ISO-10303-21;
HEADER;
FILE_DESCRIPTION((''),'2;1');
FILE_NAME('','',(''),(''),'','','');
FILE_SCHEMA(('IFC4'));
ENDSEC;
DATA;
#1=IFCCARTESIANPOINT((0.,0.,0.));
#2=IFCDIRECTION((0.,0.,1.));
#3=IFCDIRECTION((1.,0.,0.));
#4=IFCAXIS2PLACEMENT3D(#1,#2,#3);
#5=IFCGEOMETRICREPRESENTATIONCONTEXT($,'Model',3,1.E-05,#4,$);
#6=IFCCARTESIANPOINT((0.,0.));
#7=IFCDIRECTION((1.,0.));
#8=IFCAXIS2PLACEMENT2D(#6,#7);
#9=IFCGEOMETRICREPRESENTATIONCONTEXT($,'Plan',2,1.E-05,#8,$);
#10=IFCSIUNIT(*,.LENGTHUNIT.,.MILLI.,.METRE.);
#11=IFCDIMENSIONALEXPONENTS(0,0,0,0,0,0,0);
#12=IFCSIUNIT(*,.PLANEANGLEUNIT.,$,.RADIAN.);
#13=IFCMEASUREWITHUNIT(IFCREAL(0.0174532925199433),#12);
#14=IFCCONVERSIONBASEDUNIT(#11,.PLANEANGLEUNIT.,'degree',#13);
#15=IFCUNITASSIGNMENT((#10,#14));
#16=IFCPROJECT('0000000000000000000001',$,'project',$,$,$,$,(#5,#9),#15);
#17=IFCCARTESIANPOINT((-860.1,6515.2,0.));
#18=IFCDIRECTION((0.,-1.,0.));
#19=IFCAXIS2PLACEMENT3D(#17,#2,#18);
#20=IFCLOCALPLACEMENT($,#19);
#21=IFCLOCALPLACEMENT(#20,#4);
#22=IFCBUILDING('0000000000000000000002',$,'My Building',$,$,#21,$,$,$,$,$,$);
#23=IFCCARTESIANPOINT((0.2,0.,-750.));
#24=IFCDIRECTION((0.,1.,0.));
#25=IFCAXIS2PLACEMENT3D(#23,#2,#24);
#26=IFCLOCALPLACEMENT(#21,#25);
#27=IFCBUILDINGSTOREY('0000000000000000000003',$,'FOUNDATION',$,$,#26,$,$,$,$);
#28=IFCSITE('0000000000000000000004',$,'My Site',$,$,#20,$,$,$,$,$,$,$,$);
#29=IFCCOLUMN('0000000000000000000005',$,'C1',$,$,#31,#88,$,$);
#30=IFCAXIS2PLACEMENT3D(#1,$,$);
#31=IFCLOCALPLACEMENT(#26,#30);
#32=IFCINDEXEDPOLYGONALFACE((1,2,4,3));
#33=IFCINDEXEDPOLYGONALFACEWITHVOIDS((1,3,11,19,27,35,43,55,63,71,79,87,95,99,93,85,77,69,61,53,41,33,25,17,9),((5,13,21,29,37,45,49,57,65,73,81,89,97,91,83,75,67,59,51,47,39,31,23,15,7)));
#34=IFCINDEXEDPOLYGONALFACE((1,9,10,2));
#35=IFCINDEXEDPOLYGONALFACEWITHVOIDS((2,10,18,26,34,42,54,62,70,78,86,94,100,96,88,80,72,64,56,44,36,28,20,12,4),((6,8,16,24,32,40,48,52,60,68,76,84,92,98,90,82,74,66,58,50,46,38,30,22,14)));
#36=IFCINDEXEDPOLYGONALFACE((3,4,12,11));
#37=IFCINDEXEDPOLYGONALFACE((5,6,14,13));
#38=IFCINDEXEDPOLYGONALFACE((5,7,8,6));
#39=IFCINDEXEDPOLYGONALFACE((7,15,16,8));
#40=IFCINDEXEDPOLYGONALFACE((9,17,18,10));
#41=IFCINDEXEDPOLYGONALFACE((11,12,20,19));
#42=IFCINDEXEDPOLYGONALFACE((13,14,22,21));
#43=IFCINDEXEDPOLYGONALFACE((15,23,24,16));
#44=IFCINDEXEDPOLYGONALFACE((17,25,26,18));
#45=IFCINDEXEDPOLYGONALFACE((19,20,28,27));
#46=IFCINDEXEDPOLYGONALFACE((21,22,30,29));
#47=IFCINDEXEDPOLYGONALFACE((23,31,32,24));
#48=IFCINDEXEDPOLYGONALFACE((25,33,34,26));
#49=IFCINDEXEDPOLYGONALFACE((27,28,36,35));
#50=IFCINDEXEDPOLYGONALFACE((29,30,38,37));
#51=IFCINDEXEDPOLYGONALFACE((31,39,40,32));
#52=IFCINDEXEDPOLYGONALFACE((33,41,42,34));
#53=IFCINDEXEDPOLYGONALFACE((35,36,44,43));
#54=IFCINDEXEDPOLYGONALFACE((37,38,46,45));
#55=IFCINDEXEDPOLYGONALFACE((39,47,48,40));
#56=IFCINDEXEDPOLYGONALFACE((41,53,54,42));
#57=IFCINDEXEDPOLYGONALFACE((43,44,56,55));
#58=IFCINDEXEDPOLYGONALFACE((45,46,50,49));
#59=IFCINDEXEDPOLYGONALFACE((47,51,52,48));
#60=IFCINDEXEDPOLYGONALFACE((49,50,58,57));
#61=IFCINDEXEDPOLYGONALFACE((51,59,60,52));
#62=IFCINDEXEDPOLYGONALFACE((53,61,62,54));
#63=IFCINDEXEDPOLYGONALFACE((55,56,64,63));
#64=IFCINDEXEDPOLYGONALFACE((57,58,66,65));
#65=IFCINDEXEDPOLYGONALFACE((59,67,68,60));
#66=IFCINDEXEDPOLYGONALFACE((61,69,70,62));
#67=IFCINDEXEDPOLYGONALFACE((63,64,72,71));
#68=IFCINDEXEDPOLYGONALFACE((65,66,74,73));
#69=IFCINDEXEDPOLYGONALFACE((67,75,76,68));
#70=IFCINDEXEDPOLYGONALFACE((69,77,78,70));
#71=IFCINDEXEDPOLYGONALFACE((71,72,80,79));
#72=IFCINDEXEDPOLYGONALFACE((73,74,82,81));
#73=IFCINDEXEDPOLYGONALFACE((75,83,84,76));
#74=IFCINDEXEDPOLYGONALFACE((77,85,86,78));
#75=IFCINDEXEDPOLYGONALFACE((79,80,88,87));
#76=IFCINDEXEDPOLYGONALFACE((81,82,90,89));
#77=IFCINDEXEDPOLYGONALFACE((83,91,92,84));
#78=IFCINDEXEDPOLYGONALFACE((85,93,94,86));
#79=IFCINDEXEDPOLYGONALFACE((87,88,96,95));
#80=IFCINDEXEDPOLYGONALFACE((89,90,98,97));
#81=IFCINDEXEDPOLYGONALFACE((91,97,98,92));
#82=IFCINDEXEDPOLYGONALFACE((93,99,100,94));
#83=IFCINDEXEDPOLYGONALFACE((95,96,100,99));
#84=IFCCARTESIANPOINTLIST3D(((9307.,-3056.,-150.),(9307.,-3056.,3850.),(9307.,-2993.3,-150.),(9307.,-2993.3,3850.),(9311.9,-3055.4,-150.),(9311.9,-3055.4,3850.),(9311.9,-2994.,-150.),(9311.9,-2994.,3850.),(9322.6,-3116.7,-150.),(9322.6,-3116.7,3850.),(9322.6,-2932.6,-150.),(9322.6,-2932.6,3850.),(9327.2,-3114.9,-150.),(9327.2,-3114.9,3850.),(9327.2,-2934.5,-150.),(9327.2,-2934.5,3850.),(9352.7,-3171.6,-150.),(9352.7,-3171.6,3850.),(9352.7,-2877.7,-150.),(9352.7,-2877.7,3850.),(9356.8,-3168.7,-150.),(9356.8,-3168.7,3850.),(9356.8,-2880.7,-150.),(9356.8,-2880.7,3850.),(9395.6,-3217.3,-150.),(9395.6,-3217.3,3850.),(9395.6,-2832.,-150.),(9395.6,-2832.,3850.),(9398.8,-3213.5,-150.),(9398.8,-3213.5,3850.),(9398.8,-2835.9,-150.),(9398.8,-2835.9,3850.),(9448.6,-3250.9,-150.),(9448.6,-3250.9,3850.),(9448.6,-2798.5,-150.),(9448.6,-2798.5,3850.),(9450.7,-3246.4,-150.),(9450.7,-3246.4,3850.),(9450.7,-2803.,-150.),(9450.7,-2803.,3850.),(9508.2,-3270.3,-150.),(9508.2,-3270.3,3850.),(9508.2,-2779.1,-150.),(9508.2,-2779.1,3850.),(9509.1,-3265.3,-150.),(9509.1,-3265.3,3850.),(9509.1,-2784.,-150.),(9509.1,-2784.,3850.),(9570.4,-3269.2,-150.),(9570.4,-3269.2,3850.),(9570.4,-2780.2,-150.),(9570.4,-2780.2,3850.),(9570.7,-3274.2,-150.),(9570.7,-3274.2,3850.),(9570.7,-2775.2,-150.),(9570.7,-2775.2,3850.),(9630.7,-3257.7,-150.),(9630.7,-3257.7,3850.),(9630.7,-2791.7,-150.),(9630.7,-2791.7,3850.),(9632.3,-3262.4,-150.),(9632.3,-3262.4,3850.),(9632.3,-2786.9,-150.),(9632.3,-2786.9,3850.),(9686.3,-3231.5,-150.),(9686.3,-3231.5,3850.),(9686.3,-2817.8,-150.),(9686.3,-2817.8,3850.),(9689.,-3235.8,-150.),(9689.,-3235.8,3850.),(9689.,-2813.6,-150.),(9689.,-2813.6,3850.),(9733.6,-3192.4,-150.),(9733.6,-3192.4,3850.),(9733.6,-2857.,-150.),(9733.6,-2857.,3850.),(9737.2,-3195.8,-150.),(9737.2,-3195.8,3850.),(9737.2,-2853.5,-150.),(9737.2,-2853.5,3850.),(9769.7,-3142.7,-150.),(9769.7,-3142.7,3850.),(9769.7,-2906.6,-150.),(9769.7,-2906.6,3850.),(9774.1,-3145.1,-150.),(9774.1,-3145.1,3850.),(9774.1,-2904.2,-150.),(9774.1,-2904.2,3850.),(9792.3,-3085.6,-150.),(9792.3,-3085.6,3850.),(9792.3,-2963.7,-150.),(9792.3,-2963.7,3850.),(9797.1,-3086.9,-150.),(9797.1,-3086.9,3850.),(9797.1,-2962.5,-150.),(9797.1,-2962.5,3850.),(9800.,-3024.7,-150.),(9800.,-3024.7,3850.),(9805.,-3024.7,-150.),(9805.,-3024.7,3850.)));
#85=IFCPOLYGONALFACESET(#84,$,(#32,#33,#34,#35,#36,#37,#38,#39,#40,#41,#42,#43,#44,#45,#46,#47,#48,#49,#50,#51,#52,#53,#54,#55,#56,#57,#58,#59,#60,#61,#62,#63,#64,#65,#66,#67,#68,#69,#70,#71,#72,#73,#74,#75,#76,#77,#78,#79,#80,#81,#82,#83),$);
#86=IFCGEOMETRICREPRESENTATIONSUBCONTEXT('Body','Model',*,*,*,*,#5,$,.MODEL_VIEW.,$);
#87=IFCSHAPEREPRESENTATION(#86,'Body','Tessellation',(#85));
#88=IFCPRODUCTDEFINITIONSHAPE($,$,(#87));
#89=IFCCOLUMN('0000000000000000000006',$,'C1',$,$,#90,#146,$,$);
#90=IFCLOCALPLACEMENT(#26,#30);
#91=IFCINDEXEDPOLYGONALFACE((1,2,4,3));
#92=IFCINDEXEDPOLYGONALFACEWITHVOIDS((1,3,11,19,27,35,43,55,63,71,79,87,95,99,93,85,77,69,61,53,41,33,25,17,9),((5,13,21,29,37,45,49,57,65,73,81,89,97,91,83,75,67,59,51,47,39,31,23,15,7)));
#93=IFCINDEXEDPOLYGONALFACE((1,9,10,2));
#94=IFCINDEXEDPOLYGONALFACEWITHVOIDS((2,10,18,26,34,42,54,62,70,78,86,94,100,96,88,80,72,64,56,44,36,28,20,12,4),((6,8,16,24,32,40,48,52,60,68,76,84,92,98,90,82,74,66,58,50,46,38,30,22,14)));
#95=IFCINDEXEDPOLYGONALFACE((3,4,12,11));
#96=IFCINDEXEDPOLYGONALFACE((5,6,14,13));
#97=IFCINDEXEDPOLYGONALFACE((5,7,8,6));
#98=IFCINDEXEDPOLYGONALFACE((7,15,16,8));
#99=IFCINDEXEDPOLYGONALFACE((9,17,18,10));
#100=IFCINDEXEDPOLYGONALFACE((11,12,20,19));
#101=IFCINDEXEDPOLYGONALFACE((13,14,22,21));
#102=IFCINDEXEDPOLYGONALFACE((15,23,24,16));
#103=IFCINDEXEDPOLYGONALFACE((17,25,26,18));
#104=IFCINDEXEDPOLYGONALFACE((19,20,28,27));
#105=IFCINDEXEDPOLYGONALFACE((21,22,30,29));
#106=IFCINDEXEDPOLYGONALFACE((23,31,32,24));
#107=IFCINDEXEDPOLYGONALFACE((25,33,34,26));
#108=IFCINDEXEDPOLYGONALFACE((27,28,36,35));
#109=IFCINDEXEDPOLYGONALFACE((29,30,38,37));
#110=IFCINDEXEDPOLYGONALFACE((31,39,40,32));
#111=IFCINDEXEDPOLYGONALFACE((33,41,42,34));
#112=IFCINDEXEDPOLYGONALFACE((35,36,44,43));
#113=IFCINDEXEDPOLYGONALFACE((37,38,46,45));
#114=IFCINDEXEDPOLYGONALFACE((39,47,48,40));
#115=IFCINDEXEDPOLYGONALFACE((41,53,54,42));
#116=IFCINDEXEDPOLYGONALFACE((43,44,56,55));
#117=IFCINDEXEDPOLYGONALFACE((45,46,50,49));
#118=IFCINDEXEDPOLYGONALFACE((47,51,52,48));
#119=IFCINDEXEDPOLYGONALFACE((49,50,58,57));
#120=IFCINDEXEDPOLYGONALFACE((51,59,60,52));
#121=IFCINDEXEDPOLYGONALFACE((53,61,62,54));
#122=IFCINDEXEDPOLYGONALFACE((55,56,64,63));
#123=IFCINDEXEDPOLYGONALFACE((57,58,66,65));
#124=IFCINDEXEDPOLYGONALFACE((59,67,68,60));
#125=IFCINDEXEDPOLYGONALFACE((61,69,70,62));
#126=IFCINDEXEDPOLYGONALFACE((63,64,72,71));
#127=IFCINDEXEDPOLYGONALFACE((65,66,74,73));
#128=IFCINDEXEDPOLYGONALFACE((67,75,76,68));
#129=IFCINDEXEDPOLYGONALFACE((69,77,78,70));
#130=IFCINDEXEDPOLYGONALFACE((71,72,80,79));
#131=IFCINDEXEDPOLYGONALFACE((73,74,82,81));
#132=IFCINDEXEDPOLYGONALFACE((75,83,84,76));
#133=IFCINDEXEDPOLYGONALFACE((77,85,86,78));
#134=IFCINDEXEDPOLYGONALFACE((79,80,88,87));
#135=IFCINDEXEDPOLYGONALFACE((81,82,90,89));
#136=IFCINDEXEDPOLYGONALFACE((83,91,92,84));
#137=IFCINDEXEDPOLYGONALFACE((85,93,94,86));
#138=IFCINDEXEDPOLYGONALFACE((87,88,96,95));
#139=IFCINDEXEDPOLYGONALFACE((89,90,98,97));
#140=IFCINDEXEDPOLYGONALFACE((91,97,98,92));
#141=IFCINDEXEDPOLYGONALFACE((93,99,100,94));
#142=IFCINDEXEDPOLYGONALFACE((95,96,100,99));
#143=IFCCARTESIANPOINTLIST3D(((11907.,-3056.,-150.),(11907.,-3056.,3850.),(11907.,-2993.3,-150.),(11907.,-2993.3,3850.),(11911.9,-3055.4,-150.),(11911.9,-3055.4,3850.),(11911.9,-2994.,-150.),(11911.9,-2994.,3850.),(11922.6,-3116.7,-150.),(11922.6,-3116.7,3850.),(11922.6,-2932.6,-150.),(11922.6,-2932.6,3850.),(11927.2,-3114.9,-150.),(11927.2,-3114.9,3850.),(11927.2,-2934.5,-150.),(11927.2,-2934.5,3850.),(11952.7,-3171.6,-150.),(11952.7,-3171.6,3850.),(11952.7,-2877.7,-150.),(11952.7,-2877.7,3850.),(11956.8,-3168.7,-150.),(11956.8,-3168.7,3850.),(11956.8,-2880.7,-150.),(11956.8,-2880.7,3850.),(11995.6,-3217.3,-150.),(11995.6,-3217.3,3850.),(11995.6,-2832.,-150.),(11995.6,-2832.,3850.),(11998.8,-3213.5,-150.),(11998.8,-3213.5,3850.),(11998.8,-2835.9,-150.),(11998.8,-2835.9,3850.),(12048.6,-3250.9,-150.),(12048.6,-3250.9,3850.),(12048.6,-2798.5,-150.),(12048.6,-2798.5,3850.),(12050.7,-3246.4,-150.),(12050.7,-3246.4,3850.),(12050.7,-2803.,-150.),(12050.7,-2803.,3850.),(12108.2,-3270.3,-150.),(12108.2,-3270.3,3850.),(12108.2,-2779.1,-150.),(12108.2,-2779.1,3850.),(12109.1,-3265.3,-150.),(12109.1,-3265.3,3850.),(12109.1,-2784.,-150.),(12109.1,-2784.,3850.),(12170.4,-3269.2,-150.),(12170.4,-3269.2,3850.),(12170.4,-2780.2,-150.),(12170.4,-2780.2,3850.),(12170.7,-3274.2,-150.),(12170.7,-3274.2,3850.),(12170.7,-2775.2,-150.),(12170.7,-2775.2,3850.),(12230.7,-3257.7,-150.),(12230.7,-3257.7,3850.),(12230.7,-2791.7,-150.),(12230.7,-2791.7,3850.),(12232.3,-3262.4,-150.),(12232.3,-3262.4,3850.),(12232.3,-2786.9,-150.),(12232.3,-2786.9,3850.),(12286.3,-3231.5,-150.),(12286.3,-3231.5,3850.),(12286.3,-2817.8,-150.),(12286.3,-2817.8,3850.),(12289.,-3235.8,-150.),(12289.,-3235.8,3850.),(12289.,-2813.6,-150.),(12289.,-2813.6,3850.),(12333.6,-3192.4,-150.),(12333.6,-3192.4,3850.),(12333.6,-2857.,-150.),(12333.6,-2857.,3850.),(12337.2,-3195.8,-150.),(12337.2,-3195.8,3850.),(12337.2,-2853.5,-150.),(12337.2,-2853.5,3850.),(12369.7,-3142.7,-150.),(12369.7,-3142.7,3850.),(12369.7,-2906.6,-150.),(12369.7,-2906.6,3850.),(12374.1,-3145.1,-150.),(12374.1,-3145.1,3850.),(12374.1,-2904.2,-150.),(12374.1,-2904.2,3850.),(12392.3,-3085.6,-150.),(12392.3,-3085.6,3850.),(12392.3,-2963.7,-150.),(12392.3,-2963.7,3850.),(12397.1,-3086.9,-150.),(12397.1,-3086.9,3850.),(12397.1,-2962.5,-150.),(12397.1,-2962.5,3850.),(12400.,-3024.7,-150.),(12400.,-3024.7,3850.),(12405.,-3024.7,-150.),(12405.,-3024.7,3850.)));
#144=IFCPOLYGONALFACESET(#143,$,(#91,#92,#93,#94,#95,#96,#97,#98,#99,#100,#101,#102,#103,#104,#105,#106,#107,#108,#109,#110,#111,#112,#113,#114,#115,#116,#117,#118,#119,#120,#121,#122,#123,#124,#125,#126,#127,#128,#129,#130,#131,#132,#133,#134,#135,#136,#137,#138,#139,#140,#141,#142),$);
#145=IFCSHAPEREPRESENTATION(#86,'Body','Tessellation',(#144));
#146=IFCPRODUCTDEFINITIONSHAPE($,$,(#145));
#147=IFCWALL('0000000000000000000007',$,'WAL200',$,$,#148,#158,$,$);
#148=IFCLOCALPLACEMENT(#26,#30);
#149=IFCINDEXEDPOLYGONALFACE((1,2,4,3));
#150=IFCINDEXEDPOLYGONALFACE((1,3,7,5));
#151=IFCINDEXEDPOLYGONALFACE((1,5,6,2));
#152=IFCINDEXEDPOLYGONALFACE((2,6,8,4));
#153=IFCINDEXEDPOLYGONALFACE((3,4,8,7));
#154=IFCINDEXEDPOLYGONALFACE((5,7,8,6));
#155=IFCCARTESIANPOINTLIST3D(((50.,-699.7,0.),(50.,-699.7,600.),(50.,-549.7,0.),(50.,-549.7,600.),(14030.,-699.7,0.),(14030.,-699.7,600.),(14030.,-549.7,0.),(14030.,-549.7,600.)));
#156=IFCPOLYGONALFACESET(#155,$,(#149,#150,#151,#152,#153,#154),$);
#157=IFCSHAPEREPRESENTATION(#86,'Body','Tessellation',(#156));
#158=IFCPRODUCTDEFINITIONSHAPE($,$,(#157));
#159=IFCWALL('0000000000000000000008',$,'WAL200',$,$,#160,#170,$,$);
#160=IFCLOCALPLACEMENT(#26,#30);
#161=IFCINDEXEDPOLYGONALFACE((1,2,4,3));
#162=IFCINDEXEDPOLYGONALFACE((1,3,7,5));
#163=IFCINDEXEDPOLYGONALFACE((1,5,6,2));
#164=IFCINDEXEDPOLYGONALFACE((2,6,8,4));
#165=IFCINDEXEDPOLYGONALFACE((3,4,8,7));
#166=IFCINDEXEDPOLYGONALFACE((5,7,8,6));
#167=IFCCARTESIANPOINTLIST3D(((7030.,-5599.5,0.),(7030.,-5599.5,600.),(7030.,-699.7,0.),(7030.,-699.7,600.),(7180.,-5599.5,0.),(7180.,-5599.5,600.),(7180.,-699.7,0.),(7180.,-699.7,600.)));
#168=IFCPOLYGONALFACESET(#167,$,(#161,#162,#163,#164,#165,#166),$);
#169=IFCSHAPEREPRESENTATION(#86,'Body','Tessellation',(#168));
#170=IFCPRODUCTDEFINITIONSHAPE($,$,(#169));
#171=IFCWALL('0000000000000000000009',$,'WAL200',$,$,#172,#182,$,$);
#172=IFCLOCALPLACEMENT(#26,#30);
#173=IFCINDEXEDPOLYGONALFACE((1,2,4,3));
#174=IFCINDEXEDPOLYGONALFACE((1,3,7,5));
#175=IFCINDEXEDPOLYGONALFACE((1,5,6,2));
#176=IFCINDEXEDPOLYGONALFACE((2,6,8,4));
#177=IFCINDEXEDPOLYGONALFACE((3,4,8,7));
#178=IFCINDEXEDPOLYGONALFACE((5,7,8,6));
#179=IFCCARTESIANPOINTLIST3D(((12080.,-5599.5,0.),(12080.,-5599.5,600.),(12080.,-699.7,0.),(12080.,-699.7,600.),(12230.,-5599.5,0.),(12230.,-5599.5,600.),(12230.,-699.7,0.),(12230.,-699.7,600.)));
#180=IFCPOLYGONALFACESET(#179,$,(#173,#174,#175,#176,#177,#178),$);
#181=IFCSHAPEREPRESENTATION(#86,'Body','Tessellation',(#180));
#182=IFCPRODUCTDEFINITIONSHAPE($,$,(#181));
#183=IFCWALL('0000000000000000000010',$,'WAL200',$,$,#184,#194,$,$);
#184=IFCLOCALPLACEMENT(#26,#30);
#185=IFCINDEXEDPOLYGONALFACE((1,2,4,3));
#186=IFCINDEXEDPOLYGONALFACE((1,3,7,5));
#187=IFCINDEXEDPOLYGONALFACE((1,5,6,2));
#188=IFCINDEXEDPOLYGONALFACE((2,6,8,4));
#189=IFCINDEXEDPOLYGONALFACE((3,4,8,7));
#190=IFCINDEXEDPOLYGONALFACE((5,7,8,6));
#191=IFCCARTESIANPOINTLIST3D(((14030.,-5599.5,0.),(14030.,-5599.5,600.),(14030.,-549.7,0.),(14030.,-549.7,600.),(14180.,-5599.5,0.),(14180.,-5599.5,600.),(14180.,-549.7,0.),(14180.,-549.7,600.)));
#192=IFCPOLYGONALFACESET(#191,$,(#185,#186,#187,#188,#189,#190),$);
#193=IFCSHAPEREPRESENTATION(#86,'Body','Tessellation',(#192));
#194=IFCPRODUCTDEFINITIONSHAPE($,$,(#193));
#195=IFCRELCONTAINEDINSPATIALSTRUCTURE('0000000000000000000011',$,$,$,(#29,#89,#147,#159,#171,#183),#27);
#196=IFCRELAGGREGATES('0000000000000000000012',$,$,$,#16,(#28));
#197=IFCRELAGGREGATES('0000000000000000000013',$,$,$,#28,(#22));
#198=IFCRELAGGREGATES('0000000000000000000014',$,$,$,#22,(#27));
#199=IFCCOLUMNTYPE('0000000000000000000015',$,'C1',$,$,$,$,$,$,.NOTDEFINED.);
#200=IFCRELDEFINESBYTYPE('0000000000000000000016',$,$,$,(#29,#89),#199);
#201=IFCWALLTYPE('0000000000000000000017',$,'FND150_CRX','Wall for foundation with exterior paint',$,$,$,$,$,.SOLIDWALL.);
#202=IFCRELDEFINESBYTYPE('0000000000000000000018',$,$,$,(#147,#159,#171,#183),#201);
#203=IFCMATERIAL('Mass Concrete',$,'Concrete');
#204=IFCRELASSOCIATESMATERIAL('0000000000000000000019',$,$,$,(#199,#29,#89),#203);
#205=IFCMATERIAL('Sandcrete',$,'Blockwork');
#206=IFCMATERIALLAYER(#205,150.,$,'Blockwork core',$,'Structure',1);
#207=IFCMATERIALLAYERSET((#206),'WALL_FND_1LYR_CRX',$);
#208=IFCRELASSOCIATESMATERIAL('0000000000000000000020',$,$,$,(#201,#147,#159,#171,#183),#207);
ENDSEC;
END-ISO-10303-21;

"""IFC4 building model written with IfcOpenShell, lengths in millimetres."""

from ifc_helpers import new_model, entity, si_unit, converted_unit, frame, origin_with_axes, origin_2d_with_axis, place, context, subcontext, project, spatial, indexed_curve, rectangle, hollow_circle, outline, extrude, material, layer, layer_set, layer_usage, material_profile, profile_set, profile_usage, type_object, element, save


model = new_model("IFC4")

# Units and contexts
model_context = context("Model", 3, precision=1e-05, world=origin_with_axes())
plan_context = context("Plan", 2, precision=1e-05, world=origin_2d_with_axis())
body_context = subcontext(model_context, "Body", "Model", "MODEL_VIEW")
ifc_project = project(units=[si_unit("LENGTHUNIT", "METRE", prefix="MILLI"), converted_unit("PLANEANGLEUNIT", "degree", entity("IfcReal", 0.0174532925199433), si_unit("PLANEANGLEUNIT", "RADIAN"), dimensions=[0, 0, 0, 0, 0, 0, 0])], contexts=[model_context, plan_context])

# Site, building, storey
site_placement = place(None, frame((-860.1, 6515.2, 0.0), z_axis=(0.0, 0.0, 1.0), x_axis=(0.0, -1.0, 0.0)))
site = spatial("IfcSite", under=ifc_project, at=site_placement, Name="My Site")
building_placement = place(site_placement, frame((0.0, 0.0, 0.0), z_axis=(0.0, 0.0, 1.0), x_axis=(1.0, 0.0, 0.0)))
building = spatial("IfcBuilding", under=site, at=building_placement, Name="My Building")
storey_placement = place(building_placement, frame((0.2, 0.0, -750.0), z_axis=(0.0, 0.0, 1.0), x_axis=(0.0, 1.0, 0.0)))
storey = spatial("IfcBuildingStorey", under=building, at=storey_placement, Name="FOUNDATION")

# Shared definitions
ifc_material_1 = material(Name="Mass Concrete", Category="Concrete")

# Columns
ifc_material_profile = material_profile(ifc_material_1, rectangle(XDim=150.0, YDim=150.0), Name="Square Column", Category="Structure", Priority=1)
ifc_profile_set = profile_set([ifc_material_profile], Name="RC_COL_150x150")
column_type = type_object("IfcColumnType", Name="C1", PredefinedType="NOTDEFINED", material=ifc_profile_set)
ifc_profile_usage_1 = profile_usage(ifc_profile_set, cardinal=5)
column_1_placement = place(storey_placement, frame((9555.0, -3024.7, -150.0), z_axis=(0.0, 0.0, 1.0), x_axis=(1.0, 0.0, 0.0)))
element("IfcColumn", 1, at=column_1_placement, inside=storey, type_object=column_type, material=ifc_profile_usage_1, Name="C1", context=body_context, shape_type="SweptSolid", body=[
    extrude(hollow_circle(Radius=250.0, WallThickness=5.0), origin_with_axes(), (0.0, 0.0, 1.0), 4000.0),
])
ifc_profile_usage_2 = profile_usage(ifc_profile_set, cardinal=5)
column_2_placement = place(storey_placement, frame((12155.0, -3024.7, -150.0), z_axis=(0.0, 0.0, 1.0), x_axis=(1.0, 0.0, 0.0)))
element("IfcColumn", 2, at=column_2_placement, inside=storey, type_object=column_type, material=ifc_profile_usage_2, Name="C1", context=body_context, shape_type="SweptSolid", body=[
    extrude(hollow_circle(Radius=250.0, WallThickness=5.0), origin_with_axes(), (0.0, 0.0, 1.0), 4000.0),
])

# Walls
ifc_material_2 = material(Name="Sandcrete", Category="Blockwork")
ifc_layer_1 = layer(ifc_material_2, 150.0, Name="Blockwork core", Category="Structure", Priority=1)
ifc_layer_set_1 = layer_set([ifc_layer_1], Name="WALL_FND_1LYR_CRX")
ifc_layer_usage_1 = layer_usage(ifc_layer_set_1, "AXIS2", "POSITIVE", 0.0)
wall_type = type_object("IfcWallType", Name="FND150_CRX", Description="Wall for foundation with exterior paint", PredefinedType="SOLIDWALL", material=ifc_layer_set_1)
wall_1_placement = place(storey_placement, frame((14030.0, -549.7, 0.0), z_axis=(0.0, 0.0, 1.0), x_axis=(-1.0, 0.000001, 0.0)))
element("IfcWall", 3, at=wall_1_placement, inside=storey, type_object=wall_type, material=ifc_layer_usage_1, Name="WAL200", context=body_context, shape_type="SweptSolid", body=[
    extrude(outline(indexed_curve([(0.0, 0.0), (0.0, 150.0), (13980.0, 150.0), (13980.0, 0.0), (0.0, 0.0)], self_intersect=False)), origin_with_axes(), (0.0, 0.0, 1.0), 600.0),
])
ifc_layer_usage_2 = layer_usage(ifc_layer_set_1, "AXIS2", "POSITIVE", 0.0)
wall_2_placement = place(storey_placement, frame((7180.0, -5599.5, 0.0), z_axis=(0.0, 0.0, 1.0), x_axis=(0.000001, 1.0, 0.0)))
element("IfcWall", 4, at=wall_2_placement, inside=storey, type_object=wall_type, material=ifc_layer_usage_2, Name="WAL200", context=body_context, shape_type="SweptSolid", body=[
    extrude(outline(indexed_curve([(0.0, 0.0), (0.0, 150.0), (4899.8, 150.0), (4899.8, 0.0), (0.0, 0.0)], self_intersect=False)), origin_with_axes(), (0.0, 0.0, 1.0), 600.0),
])
ifc_layer_usage_3 = layer_usage(ifc_layer_set_1, "AXIS2", "POSITIVE", 0.0)
wall_3_placement = place(storey_placement, frame((12080.0, -699.7, 0.0), z_axis=(0.0, 0.0, 1.0), x_axis=(0.0, -1.0, 0.0)))
element("IfcWall", 5, at=wall_3_placement, inside=storey, type_object=wall_type, material=ifc_layer_usage_3, Name="WAL200", context=body_context, shape_type="SweptSolid", body=[
    extrude(outline(indexed_curve([(0.0, 0.0), (0.0, 150.0), (4899.8, 150.0), (4899.8, 0.0), (0.0, 0.0)], self_intersect=False)), origin_with_axes(), (0.0, 0.0, 1.0), 600.0),
])
ifc_layer_usage_4 = layer_usage(ifc_layer_set_1, "AXIS2", "POSITIVE", 0.0)
wall_4_placement = place(storey_placement, frame((14180.0, -5599.5, 0.0), z_axis=(0.0, 0.0, 1.0), x_axis=(0.0, 1.0, 0.0)))
element("IfcWall", 6, at=wall_4_placement, inside=storey, type_object=wall_type, material=ifc_layer_usage_4, Name="WAL200", context=body_context, shape_type="SweptSolid", body=[
    extrude(outline(indexed_curve([(0.0, 0.0), (0.0, 150.0), (5049.8, 150.0), (5049.8, 0.0), (0.0, 0.0)], self_intersect=False)), origin_with_axes(), (0.0, 0.0, 1.0), 600.0),
])

save(model, "model.ifc")
